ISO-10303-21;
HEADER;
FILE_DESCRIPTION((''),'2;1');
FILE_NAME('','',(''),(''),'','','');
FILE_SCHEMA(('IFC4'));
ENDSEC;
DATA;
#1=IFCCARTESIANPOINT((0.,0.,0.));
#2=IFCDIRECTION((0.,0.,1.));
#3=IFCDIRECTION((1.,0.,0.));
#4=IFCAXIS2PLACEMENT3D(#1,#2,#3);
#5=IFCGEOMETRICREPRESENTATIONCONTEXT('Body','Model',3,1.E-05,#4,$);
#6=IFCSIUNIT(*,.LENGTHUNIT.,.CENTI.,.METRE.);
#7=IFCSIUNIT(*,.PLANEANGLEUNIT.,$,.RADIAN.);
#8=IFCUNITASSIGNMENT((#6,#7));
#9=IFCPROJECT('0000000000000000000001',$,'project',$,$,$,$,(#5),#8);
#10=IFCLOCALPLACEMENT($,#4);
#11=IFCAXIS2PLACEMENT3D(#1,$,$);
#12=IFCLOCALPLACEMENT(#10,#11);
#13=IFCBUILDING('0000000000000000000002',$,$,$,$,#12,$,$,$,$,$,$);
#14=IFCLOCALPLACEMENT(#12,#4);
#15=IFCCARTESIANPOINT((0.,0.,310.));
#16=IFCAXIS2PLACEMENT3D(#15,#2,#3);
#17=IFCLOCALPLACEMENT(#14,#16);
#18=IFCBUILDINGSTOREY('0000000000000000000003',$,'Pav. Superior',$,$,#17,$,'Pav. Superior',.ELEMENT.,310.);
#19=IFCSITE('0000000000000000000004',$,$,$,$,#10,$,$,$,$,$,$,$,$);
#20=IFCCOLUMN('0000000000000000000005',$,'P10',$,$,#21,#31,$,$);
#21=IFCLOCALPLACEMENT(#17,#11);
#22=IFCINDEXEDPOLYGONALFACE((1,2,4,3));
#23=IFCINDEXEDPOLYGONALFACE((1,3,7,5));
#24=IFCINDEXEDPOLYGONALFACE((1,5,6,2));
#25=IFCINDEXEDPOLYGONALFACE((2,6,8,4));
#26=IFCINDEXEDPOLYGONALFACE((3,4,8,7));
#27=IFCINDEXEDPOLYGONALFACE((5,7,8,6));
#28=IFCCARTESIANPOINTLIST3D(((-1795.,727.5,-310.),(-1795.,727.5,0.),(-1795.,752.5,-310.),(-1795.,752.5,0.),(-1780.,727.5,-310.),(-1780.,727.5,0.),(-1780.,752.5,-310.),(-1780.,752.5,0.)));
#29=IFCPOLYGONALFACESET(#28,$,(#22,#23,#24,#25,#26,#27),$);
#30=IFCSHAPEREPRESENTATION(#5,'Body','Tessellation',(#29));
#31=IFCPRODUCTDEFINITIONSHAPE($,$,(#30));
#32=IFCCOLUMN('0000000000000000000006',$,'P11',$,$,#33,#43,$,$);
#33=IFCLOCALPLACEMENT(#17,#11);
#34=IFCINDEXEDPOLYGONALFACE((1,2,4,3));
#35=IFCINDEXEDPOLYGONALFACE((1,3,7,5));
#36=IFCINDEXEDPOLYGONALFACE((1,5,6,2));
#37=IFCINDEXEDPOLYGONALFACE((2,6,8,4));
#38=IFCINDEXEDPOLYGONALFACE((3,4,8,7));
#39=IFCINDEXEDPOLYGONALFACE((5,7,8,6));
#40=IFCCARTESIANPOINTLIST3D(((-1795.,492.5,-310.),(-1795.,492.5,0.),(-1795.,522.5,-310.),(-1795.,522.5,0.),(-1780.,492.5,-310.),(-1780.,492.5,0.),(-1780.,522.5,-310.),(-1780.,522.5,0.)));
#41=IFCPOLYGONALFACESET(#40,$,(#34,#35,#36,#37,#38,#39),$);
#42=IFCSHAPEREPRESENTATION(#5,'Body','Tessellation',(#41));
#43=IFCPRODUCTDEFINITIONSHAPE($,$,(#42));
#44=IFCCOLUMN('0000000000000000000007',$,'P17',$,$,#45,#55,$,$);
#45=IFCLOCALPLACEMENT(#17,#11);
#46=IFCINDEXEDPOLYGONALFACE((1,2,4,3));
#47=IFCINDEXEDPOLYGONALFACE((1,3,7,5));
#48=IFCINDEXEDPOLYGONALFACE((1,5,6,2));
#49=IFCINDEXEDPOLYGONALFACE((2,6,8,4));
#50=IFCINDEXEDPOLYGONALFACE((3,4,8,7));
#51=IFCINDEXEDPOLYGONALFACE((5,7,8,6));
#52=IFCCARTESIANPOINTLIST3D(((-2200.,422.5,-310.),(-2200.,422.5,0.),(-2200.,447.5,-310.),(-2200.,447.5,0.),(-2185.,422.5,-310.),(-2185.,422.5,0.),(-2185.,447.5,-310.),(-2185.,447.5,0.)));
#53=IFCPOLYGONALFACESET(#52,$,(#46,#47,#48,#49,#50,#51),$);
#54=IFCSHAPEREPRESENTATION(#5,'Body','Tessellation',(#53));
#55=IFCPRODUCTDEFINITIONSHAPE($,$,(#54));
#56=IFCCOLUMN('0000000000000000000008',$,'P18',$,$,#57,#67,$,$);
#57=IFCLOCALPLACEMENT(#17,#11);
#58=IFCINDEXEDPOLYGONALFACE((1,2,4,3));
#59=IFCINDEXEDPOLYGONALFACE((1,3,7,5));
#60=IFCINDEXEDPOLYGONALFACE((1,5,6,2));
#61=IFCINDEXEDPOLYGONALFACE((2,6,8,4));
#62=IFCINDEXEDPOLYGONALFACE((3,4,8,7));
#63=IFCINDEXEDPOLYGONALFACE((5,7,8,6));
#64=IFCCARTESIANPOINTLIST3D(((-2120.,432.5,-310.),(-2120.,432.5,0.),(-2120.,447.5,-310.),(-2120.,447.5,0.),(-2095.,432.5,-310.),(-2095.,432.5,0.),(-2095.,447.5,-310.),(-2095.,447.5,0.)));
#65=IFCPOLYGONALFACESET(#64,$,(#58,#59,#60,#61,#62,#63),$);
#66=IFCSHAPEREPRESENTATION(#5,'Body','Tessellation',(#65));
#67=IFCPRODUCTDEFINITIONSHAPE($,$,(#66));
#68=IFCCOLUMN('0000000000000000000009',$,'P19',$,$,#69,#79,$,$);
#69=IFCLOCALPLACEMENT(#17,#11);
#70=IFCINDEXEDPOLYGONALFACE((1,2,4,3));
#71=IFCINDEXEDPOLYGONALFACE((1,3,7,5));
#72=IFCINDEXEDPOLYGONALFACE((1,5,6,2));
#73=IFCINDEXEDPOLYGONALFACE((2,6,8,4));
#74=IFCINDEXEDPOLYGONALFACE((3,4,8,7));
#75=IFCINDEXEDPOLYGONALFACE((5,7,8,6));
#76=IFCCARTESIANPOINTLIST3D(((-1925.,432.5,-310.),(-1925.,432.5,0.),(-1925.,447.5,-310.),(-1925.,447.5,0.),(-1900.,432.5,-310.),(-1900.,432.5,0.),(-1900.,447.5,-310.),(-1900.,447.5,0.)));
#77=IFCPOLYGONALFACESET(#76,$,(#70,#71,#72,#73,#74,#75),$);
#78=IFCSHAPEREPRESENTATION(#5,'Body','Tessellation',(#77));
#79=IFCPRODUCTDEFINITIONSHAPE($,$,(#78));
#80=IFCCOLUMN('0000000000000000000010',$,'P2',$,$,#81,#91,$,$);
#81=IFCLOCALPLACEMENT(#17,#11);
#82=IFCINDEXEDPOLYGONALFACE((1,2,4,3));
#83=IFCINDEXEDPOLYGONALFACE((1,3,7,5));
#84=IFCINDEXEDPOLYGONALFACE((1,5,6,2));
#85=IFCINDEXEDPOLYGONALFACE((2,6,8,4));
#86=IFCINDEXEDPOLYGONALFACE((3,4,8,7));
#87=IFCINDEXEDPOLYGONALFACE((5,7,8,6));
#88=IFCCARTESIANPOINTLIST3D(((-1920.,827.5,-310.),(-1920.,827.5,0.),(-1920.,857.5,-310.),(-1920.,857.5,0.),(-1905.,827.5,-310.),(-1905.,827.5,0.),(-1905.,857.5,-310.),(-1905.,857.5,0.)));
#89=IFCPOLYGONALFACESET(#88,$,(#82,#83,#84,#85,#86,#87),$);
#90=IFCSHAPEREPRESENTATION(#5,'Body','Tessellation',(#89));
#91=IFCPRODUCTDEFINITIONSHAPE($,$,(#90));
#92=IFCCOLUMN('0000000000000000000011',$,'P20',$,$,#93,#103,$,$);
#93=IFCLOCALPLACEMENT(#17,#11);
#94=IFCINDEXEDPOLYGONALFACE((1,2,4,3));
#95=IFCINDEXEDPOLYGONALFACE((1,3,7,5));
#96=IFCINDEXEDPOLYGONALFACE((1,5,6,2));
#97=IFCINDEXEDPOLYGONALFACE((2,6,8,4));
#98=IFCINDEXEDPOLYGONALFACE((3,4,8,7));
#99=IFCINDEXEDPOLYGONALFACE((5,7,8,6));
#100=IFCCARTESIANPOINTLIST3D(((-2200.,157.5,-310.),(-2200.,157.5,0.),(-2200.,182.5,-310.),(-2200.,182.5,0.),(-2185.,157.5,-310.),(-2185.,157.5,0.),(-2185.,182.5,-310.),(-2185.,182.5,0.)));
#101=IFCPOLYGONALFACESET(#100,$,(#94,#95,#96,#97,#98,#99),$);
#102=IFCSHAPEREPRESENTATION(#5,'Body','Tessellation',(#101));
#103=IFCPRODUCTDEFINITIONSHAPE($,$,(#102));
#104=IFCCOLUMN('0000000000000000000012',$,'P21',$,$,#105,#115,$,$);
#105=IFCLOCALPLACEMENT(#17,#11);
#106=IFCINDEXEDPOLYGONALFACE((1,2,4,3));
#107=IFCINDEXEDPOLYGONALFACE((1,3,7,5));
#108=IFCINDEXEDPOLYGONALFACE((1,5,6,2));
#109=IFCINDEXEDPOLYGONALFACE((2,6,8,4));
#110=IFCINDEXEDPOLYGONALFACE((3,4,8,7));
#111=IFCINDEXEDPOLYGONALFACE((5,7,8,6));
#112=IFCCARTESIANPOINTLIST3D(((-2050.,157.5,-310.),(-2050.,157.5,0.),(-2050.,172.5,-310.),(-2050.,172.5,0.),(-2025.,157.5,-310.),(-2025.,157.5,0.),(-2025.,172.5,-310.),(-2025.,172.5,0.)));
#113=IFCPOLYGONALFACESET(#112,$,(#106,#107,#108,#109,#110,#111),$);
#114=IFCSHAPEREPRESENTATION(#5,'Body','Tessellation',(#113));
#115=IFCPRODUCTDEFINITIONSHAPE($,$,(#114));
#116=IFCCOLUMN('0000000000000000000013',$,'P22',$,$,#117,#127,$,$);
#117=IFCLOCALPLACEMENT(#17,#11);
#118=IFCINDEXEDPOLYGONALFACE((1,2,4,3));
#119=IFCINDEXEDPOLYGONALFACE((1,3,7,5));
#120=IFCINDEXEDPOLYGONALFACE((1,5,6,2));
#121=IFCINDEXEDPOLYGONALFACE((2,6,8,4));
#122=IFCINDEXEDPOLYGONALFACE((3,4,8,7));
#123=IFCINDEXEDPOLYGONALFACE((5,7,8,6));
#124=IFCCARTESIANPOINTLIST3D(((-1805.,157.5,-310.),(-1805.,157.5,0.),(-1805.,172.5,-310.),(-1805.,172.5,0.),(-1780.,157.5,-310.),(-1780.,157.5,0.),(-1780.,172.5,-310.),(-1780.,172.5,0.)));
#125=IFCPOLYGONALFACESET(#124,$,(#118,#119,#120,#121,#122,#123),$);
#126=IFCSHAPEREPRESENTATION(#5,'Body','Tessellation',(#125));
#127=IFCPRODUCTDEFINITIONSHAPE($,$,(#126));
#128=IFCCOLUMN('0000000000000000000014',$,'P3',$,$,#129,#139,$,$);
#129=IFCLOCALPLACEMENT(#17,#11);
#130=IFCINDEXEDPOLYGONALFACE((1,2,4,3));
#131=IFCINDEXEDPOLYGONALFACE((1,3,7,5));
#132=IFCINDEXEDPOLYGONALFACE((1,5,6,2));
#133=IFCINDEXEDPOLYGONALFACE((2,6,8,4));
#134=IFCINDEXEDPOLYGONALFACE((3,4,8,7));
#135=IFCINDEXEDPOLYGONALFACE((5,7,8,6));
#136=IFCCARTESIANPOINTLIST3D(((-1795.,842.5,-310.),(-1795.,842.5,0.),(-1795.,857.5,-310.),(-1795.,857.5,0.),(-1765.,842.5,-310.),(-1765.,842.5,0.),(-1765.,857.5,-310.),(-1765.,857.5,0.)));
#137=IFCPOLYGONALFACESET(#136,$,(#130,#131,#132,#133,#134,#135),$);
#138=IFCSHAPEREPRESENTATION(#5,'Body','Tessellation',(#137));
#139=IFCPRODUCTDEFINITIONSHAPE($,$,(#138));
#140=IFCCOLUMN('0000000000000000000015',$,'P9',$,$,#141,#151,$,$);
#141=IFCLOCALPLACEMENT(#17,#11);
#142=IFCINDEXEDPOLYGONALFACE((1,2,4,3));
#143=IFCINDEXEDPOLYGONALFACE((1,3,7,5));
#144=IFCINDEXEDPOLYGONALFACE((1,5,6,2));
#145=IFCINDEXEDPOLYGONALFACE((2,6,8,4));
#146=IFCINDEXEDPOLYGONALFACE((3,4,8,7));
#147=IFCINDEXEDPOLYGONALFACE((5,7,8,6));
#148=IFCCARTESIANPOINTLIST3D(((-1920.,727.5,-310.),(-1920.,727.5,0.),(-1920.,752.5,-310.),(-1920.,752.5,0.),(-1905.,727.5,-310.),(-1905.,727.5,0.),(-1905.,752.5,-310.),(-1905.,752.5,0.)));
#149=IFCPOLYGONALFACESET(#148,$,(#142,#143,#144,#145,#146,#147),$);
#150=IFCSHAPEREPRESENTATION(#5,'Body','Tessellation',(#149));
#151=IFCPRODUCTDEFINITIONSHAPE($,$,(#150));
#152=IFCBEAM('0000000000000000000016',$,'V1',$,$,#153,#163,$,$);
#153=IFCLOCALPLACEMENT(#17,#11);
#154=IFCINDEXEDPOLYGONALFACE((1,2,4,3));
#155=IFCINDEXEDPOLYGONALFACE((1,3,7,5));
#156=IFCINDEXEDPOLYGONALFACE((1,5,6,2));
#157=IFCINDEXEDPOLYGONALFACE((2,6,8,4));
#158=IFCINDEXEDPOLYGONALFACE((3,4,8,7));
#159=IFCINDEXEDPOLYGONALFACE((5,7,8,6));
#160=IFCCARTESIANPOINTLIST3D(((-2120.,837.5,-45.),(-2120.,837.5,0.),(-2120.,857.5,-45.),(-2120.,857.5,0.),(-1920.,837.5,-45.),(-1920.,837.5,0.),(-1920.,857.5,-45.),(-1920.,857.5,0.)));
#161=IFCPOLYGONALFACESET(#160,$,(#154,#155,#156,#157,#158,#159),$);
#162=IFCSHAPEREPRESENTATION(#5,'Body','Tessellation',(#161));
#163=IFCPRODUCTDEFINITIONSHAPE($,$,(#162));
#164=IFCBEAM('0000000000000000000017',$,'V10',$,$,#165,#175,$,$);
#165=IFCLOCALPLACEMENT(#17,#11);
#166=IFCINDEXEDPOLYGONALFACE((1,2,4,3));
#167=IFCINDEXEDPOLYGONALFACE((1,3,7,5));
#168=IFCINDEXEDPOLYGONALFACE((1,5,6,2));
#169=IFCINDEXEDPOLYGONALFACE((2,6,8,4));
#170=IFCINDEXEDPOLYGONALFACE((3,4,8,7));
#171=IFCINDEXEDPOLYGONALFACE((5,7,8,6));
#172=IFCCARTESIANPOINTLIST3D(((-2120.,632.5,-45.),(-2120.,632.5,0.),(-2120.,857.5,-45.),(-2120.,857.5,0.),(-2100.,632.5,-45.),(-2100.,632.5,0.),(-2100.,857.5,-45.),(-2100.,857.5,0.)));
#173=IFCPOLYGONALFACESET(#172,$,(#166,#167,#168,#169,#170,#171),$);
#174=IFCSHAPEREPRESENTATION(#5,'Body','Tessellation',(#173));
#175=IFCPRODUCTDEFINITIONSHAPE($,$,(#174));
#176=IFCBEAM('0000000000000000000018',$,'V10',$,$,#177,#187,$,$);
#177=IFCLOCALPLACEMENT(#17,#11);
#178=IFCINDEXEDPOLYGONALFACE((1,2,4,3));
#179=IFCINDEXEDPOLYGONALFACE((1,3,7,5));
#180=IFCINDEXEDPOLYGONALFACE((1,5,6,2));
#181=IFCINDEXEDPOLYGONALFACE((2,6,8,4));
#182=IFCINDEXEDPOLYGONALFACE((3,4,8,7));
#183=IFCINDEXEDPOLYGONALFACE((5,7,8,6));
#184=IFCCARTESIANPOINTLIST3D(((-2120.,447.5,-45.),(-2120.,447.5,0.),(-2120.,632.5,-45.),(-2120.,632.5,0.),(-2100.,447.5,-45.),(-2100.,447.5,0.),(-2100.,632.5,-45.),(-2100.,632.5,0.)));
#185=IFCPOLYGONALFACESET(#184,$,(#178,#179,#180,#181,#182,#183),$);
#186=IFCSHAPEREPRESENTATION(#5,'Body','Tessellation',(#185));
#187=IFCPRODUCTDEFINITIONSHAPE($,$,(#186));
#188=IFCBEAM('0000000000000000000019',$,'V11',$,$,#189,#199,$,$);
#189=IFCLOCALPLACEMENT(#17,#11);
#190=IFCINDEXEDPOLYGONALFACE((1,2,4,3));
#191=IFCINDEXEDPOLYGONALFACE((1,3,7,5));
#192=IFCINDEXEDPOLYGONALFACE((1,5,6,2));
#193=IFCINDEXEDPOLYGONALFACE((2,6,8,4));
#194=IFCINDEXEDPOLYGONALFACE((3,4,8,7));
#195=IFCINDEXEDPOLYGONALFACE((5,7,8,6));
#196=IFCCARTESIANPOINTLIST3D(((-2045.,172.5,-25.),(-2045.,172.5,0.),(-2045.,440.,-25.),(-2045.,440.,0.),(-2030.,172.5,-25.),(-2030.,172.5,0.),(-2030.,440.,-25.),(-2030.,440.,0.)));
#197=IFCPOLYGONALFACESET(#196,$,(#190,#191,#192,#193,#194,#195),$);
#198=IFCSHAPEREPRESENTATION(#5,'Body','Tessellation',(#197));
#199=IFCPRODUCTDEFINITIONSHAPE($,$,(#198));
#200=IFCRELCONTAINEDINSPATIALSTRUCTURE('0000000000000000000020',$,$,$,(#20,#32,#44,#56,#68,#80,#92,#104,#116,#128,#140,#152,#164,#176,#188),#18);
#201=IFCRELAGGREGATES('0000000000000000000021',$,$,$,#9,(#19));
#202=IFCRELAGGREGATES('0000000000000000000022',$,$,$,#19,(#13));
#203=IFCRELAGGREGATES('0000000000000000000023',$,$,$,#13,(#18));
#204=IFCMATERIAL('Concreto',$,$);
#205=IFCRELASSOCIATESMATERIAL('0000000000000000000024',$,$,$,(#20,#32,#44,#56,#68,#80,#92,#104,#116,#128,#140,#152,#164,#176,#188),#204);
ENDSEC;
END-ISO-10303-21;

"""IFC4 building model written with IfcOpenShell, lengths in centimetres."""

from ifc_helpers import new_model, si_unit, frame, origin, origin_with_axes, origin_2d_with_axis, place, context, project, spatial, rectangle, extrude, material, element, save


model = new_model("IFC4")

# Units and contexts
model_context = context("Model", 3, precision=1e-05, world=origin_with_axes(), identifier="Body")
ifc_project = project(units=[si_unit("LENGTHUNIT", "METRE", prefix="CENTI"), si_unit("PLANEANGLEUNIT", "RADIAN")], contexts=[model_context])

# Site, building, storey
site_placement = place(None, origin_with_axes())
site = spatial("IfcSite", under=ifc_project, at=site_placement)
building_placement = place(site_placement, origin())
building = spatial("IfcBuilding", under=site, at=building_placement)
placement = place(building_placement, origin_with_axes())
storey_placement = place(placement, frame((0.0, 0.0, 310.0), z_axis=(0.0, 0.0, 1.0), x_axis=(1.0, 0.0, 0.0)))
storey = spatial("IfcBuildingStorey", under=building, at=storey_placement, Name="Pav. Superior", LongName="Pav. Superior", CompositionType="ELEMENT", Elevation=310.0)

# Columns
ifc_material = material(Name="Concreto")
column_1_placement = place(storey_placement, frame((-1787.5, 740.0, 0.0), z_axis=(0.0, 0.0, 1.0), x_axis=(1.0, 0.0, 0.0)))
element("IfcColumn", 1, at=column_1_placement, inside=storey, material=ifc_material, Name="P10", context=model_context, shape_type="SolidModel", body=[
    extrude(rectangle(XDim=15.0, YDim=25.0, at=origin_2d_with_axis()), origin_with_axes(), (0.0, 0.0, -1.0), 310.0),
])
column_2_placement = place(storey_placement, frame((-1787.5, 507.5, 0.0), z_axis=(0.0, 0.0, 1.0), x_axis=(1.0, 0.0, 0.0)))
element("IfcColumn", 2, at=column_2_placement, inside=storey, material=ifc_material, Name="P11", context=model_context, shape_type="SolidModel", body=[
    extrude(rectangle(XDim=15.0, YDim=30.0, at=origin_2d_with_axis()), origin_with_axes(), (0.0, 0.0, -1.0), 310.0),
])
column_3_placement = place(storey_placement, frame((-2192.5, 435.0, 0.0), z_axis=(0.0, 0.0, 1.0), x_axis=(1.0, 0.0, 0.0)))
element("IfcColumn", 3, at=column_3_placement, inside=storey, material=ifc_material, Name="P17", context=model_context, shape_type="SolidModel", body=[
    extrude(rectangle(XDim=15.0, YDim=25.0, at=origin_2d_with_axis()), frame((0.0, 0.0, 0.0), z_axis=(0.0, 0.0, 1.0), x_axis=(-1.0, 0.0, 0.0)), (0.0, 0.0, -1.0), 310.0),
])
for number, where, z_axis, x_axis, name in (
    (4, (-2107.5, 440.0, 0.0), (0.0, 0.0, 1.0), (1.0, 0.0, 0.0), "P18"),
    (5, (-1912.5, 440.0, 0.0), (0.0, 0.0, 1.0), (1.0, 0.0, 0.0), "P19"),
):
    element("IfcColumn", number, at=place(storey_placement, frame(where, z_axis=z_axis, x_axis=x_axis)), inside=storey, material=ifc_material, Name=name, context=model_context, shape_type="SolidModel", body=[
        extrude(rectangle(XDim=15.0, YDim=25.0, at=origin_2d_with_axis()), frame((0.0, 0.0, 0.0), z_axis=(0.0, 0.0, 1.0), x_axis=(0.0, 1.0, 0.0)), (0.0, 0.0, -1.0), 310.0),
    ])
column_4_placement = place(storey_placement, frame((-1912.5, 842.5, 0.0), z_axis=(0.0, 0.0, 1.0), x_axis=(1.0, 0.0, 0.0)))
element("IfcColumn", 6, at=column_4_placement, inside=storey, material=ifc_material, Name="P2", context=model_context, shape_type="SolidModel", body=[
    extrude(rectangle(XDim=15.0, YDim=30.0, at=origin_2d_with_axis()), origin_with_axes(), (0.0, 0.0, -1.0), 310.0),
])
column_5_placement = place(storey_placement, frame((-2192.5, 170.0, 0.0), z_axis=(0.0, 0.0, 1.0), x_axis=(1.0, 0.0, 0.0)))
element("IfcColumn", 7, at=column_5_placement, inside=storey, material=ifc_material, Name="P20", context=model_context, shape_type="SolidModel", body=[
    extrude(rectangle(XDim=15.0, YDim=25.0, at=origin_2d_with_axis()), origin_with_axes(), (0.0, 0.0, -1.0), 310.0),
])
column_6_placement = place(storey_placement, frame((-2037.5, 165.0, 0.0), z_axis=(0.0, 0.0, 1.0), x_axis=(1.0, 0.0, 0.0)))
element("IfcColumn", 8, at=column_6_placement, inside=storey, material=ifc_material, Name="P21", context=model_context, shape_type="SolidModel", body=[
    extrude(rectangle(XDim=15.0, YDim=25.0, at=origin_2d_with_axis()), frame((0.0, 0.0, 0.0), z_axis=(0.0, 0.0, 1.0), x_axis=(0.0, 1.0, 0.0)), (0.0, 0.0, -1.0), 310.0),
])
column_7_placement = place(storey_placement, frame((-1792.5, 165.0, 0.0), z_axis=(0.0, 0.0, 1.0), x_axis=(1.0, 0.0, 0.0)))
element("IfcColumn", 9, at=column_7_placement, inside=storey, material=ifc_material, Name="P22", context=model_context, shape_type="SolidModel", body=[
    extrude(rectangle(XDim=15.0, YDim=25.0, at=origin_2d_with_axis()), frame((0.0, 0.0, 0.0), z_axis=(0.0, 0.0, 1.0), x_axis=(0.0, -1.0, 0.0)), (0.0, 0.0, -1.0), 310.0),
])
column_8_placement = place(storey_placement, frame((-1780.0, 850.0, 0.0), z_axis=(0.0, 0.0, 1.0), x_axis=(1.0, 0.0, 0.0)))
element("IfcColumn", 10, at=column_8_placement, inside=storey, material=ifc_material, Name="P3", context=model_context, shape_type="SolidModel", body=[
    extrude(rectangle(XDim=15.0, YDim=30.0, at=origin_2d_with_axis()), frame((0.0, 0.0, 0.0), z_axis=(0.0, 0.0, 1.0), x_axis=(0.0, 1.0, 0.0)), (0.0, 0.0, -1.0), 310.0),
])
column_9_placement = place(storey_placement, frame((-1912.5, 740.0, 0.0), z_axis=(0.0, 0.0, 1.0), x_axis=(1.0, 0.0, 0.0)))
element("IfcColumn", 11, at=column_9_placement, inside=storey, material=ifc_material, Name="P9", context=model_context, shape_type="SolidModel", body=[
    extrude(rectangle(XDim=15.0, YDim=25.0, at=origin_2d_with_axis()), frame((0.0, 0.0, 0.0), z_axis=(0.0, 0.0, 1.0), x_axis=(-1.0, 0.0, 0.0)), (0.0, 0.0, -1.0), 310.0),
])

# Beams
beam_1_placement = place(storey_placement, frame((-2020.0, 847.5, 0.0), z_axis=(0.0, 0.0, 1.0), x_axis=(1.0, 0.0, 0.0)))
element("IfcBeam", 12, at=beam_1_placement, inside=storey, material=ifc_material, Name="V1", context=model_context, shape_type="SolidModel", body=[
    extrude(rectangle(XDim=20.0, YDim=45.0, at=origin_2d_with_axis()), frame((-100.0, 0.0, -22.5), z_axis=(1.0, 0.0, 0.0), x_axis=(0.0, -1.0, 0.0)), (0.0, 0.0, 1.0), 200.0),
])
beam_2_placement = place(storey_placement, frame((-2110.0, 745.0, 0.0), z_axis=(0.0, 0.0, 1.0), x_axis=(1.0, 0.0, 0.0)))
element("IfcBeam", 13, at=beam_2_placement, inside=storey, material=ifc_material, Name="V10", context=model_context, shape_type="SolidModel", body=[
    extrude(rectangle(XDim=20.0, YDim=45.0, at=origin_2d_with_axis()), frame((0.0, -112.5, -22.5), z_axis=(0.0, 1.0, 0.0), x_axis=(-1.0, 0.0, 0.0)), (0.0, 0.0, 1.0), 225.0),
])
beam_3_placement = place(storey_placement, frame((-2110.0, 540.0, 0.0), z_axis=(0.0, 0.0, 1.0), x_axis=(1.0, 0.0, 0.0)))
element("IfcBeam", 14, at=beam_3_placement, inside=storey, material=ifc_material, Name="V10", context=model_context, shape_type="SolidModel", body=[
    extrude(rectangle(XDim=20.0, YDim=45.0, at=origin_2d_with_axis()), frame((0.0, -92.5, -22.5), z_axis=(0.0, 1.0, 0.0), x_axis=(-1.0, 0.0, 0.0)), (0.0, 0.0, 1.0), 185.0),
])
beam_4_placement = place(storey_placement, frame((-2037.5, 306.25, 0.0), z_axis=(0.0, 0.0, 1.0), x_axis=(1.0, 0.0, 0.0)))
element("IfcBeam", 15, at=beam_4_placement, inside=storey, material=ifc_material, Name="V11", context=model_context, shape_type="SolidModel", body=[
    extrude(rectangle(XDim=15.0, YDim=25.0, at=origin_2d_with_axis()), frame((0.0, -133.75, -12.5), z_axis=(0.0, 1.0, 0.0), x_axis=(-1.0, 0.0, 0.0)), (0.0, 0.0, 1.0), 267.5),
])

save(model, "model.ifc")
